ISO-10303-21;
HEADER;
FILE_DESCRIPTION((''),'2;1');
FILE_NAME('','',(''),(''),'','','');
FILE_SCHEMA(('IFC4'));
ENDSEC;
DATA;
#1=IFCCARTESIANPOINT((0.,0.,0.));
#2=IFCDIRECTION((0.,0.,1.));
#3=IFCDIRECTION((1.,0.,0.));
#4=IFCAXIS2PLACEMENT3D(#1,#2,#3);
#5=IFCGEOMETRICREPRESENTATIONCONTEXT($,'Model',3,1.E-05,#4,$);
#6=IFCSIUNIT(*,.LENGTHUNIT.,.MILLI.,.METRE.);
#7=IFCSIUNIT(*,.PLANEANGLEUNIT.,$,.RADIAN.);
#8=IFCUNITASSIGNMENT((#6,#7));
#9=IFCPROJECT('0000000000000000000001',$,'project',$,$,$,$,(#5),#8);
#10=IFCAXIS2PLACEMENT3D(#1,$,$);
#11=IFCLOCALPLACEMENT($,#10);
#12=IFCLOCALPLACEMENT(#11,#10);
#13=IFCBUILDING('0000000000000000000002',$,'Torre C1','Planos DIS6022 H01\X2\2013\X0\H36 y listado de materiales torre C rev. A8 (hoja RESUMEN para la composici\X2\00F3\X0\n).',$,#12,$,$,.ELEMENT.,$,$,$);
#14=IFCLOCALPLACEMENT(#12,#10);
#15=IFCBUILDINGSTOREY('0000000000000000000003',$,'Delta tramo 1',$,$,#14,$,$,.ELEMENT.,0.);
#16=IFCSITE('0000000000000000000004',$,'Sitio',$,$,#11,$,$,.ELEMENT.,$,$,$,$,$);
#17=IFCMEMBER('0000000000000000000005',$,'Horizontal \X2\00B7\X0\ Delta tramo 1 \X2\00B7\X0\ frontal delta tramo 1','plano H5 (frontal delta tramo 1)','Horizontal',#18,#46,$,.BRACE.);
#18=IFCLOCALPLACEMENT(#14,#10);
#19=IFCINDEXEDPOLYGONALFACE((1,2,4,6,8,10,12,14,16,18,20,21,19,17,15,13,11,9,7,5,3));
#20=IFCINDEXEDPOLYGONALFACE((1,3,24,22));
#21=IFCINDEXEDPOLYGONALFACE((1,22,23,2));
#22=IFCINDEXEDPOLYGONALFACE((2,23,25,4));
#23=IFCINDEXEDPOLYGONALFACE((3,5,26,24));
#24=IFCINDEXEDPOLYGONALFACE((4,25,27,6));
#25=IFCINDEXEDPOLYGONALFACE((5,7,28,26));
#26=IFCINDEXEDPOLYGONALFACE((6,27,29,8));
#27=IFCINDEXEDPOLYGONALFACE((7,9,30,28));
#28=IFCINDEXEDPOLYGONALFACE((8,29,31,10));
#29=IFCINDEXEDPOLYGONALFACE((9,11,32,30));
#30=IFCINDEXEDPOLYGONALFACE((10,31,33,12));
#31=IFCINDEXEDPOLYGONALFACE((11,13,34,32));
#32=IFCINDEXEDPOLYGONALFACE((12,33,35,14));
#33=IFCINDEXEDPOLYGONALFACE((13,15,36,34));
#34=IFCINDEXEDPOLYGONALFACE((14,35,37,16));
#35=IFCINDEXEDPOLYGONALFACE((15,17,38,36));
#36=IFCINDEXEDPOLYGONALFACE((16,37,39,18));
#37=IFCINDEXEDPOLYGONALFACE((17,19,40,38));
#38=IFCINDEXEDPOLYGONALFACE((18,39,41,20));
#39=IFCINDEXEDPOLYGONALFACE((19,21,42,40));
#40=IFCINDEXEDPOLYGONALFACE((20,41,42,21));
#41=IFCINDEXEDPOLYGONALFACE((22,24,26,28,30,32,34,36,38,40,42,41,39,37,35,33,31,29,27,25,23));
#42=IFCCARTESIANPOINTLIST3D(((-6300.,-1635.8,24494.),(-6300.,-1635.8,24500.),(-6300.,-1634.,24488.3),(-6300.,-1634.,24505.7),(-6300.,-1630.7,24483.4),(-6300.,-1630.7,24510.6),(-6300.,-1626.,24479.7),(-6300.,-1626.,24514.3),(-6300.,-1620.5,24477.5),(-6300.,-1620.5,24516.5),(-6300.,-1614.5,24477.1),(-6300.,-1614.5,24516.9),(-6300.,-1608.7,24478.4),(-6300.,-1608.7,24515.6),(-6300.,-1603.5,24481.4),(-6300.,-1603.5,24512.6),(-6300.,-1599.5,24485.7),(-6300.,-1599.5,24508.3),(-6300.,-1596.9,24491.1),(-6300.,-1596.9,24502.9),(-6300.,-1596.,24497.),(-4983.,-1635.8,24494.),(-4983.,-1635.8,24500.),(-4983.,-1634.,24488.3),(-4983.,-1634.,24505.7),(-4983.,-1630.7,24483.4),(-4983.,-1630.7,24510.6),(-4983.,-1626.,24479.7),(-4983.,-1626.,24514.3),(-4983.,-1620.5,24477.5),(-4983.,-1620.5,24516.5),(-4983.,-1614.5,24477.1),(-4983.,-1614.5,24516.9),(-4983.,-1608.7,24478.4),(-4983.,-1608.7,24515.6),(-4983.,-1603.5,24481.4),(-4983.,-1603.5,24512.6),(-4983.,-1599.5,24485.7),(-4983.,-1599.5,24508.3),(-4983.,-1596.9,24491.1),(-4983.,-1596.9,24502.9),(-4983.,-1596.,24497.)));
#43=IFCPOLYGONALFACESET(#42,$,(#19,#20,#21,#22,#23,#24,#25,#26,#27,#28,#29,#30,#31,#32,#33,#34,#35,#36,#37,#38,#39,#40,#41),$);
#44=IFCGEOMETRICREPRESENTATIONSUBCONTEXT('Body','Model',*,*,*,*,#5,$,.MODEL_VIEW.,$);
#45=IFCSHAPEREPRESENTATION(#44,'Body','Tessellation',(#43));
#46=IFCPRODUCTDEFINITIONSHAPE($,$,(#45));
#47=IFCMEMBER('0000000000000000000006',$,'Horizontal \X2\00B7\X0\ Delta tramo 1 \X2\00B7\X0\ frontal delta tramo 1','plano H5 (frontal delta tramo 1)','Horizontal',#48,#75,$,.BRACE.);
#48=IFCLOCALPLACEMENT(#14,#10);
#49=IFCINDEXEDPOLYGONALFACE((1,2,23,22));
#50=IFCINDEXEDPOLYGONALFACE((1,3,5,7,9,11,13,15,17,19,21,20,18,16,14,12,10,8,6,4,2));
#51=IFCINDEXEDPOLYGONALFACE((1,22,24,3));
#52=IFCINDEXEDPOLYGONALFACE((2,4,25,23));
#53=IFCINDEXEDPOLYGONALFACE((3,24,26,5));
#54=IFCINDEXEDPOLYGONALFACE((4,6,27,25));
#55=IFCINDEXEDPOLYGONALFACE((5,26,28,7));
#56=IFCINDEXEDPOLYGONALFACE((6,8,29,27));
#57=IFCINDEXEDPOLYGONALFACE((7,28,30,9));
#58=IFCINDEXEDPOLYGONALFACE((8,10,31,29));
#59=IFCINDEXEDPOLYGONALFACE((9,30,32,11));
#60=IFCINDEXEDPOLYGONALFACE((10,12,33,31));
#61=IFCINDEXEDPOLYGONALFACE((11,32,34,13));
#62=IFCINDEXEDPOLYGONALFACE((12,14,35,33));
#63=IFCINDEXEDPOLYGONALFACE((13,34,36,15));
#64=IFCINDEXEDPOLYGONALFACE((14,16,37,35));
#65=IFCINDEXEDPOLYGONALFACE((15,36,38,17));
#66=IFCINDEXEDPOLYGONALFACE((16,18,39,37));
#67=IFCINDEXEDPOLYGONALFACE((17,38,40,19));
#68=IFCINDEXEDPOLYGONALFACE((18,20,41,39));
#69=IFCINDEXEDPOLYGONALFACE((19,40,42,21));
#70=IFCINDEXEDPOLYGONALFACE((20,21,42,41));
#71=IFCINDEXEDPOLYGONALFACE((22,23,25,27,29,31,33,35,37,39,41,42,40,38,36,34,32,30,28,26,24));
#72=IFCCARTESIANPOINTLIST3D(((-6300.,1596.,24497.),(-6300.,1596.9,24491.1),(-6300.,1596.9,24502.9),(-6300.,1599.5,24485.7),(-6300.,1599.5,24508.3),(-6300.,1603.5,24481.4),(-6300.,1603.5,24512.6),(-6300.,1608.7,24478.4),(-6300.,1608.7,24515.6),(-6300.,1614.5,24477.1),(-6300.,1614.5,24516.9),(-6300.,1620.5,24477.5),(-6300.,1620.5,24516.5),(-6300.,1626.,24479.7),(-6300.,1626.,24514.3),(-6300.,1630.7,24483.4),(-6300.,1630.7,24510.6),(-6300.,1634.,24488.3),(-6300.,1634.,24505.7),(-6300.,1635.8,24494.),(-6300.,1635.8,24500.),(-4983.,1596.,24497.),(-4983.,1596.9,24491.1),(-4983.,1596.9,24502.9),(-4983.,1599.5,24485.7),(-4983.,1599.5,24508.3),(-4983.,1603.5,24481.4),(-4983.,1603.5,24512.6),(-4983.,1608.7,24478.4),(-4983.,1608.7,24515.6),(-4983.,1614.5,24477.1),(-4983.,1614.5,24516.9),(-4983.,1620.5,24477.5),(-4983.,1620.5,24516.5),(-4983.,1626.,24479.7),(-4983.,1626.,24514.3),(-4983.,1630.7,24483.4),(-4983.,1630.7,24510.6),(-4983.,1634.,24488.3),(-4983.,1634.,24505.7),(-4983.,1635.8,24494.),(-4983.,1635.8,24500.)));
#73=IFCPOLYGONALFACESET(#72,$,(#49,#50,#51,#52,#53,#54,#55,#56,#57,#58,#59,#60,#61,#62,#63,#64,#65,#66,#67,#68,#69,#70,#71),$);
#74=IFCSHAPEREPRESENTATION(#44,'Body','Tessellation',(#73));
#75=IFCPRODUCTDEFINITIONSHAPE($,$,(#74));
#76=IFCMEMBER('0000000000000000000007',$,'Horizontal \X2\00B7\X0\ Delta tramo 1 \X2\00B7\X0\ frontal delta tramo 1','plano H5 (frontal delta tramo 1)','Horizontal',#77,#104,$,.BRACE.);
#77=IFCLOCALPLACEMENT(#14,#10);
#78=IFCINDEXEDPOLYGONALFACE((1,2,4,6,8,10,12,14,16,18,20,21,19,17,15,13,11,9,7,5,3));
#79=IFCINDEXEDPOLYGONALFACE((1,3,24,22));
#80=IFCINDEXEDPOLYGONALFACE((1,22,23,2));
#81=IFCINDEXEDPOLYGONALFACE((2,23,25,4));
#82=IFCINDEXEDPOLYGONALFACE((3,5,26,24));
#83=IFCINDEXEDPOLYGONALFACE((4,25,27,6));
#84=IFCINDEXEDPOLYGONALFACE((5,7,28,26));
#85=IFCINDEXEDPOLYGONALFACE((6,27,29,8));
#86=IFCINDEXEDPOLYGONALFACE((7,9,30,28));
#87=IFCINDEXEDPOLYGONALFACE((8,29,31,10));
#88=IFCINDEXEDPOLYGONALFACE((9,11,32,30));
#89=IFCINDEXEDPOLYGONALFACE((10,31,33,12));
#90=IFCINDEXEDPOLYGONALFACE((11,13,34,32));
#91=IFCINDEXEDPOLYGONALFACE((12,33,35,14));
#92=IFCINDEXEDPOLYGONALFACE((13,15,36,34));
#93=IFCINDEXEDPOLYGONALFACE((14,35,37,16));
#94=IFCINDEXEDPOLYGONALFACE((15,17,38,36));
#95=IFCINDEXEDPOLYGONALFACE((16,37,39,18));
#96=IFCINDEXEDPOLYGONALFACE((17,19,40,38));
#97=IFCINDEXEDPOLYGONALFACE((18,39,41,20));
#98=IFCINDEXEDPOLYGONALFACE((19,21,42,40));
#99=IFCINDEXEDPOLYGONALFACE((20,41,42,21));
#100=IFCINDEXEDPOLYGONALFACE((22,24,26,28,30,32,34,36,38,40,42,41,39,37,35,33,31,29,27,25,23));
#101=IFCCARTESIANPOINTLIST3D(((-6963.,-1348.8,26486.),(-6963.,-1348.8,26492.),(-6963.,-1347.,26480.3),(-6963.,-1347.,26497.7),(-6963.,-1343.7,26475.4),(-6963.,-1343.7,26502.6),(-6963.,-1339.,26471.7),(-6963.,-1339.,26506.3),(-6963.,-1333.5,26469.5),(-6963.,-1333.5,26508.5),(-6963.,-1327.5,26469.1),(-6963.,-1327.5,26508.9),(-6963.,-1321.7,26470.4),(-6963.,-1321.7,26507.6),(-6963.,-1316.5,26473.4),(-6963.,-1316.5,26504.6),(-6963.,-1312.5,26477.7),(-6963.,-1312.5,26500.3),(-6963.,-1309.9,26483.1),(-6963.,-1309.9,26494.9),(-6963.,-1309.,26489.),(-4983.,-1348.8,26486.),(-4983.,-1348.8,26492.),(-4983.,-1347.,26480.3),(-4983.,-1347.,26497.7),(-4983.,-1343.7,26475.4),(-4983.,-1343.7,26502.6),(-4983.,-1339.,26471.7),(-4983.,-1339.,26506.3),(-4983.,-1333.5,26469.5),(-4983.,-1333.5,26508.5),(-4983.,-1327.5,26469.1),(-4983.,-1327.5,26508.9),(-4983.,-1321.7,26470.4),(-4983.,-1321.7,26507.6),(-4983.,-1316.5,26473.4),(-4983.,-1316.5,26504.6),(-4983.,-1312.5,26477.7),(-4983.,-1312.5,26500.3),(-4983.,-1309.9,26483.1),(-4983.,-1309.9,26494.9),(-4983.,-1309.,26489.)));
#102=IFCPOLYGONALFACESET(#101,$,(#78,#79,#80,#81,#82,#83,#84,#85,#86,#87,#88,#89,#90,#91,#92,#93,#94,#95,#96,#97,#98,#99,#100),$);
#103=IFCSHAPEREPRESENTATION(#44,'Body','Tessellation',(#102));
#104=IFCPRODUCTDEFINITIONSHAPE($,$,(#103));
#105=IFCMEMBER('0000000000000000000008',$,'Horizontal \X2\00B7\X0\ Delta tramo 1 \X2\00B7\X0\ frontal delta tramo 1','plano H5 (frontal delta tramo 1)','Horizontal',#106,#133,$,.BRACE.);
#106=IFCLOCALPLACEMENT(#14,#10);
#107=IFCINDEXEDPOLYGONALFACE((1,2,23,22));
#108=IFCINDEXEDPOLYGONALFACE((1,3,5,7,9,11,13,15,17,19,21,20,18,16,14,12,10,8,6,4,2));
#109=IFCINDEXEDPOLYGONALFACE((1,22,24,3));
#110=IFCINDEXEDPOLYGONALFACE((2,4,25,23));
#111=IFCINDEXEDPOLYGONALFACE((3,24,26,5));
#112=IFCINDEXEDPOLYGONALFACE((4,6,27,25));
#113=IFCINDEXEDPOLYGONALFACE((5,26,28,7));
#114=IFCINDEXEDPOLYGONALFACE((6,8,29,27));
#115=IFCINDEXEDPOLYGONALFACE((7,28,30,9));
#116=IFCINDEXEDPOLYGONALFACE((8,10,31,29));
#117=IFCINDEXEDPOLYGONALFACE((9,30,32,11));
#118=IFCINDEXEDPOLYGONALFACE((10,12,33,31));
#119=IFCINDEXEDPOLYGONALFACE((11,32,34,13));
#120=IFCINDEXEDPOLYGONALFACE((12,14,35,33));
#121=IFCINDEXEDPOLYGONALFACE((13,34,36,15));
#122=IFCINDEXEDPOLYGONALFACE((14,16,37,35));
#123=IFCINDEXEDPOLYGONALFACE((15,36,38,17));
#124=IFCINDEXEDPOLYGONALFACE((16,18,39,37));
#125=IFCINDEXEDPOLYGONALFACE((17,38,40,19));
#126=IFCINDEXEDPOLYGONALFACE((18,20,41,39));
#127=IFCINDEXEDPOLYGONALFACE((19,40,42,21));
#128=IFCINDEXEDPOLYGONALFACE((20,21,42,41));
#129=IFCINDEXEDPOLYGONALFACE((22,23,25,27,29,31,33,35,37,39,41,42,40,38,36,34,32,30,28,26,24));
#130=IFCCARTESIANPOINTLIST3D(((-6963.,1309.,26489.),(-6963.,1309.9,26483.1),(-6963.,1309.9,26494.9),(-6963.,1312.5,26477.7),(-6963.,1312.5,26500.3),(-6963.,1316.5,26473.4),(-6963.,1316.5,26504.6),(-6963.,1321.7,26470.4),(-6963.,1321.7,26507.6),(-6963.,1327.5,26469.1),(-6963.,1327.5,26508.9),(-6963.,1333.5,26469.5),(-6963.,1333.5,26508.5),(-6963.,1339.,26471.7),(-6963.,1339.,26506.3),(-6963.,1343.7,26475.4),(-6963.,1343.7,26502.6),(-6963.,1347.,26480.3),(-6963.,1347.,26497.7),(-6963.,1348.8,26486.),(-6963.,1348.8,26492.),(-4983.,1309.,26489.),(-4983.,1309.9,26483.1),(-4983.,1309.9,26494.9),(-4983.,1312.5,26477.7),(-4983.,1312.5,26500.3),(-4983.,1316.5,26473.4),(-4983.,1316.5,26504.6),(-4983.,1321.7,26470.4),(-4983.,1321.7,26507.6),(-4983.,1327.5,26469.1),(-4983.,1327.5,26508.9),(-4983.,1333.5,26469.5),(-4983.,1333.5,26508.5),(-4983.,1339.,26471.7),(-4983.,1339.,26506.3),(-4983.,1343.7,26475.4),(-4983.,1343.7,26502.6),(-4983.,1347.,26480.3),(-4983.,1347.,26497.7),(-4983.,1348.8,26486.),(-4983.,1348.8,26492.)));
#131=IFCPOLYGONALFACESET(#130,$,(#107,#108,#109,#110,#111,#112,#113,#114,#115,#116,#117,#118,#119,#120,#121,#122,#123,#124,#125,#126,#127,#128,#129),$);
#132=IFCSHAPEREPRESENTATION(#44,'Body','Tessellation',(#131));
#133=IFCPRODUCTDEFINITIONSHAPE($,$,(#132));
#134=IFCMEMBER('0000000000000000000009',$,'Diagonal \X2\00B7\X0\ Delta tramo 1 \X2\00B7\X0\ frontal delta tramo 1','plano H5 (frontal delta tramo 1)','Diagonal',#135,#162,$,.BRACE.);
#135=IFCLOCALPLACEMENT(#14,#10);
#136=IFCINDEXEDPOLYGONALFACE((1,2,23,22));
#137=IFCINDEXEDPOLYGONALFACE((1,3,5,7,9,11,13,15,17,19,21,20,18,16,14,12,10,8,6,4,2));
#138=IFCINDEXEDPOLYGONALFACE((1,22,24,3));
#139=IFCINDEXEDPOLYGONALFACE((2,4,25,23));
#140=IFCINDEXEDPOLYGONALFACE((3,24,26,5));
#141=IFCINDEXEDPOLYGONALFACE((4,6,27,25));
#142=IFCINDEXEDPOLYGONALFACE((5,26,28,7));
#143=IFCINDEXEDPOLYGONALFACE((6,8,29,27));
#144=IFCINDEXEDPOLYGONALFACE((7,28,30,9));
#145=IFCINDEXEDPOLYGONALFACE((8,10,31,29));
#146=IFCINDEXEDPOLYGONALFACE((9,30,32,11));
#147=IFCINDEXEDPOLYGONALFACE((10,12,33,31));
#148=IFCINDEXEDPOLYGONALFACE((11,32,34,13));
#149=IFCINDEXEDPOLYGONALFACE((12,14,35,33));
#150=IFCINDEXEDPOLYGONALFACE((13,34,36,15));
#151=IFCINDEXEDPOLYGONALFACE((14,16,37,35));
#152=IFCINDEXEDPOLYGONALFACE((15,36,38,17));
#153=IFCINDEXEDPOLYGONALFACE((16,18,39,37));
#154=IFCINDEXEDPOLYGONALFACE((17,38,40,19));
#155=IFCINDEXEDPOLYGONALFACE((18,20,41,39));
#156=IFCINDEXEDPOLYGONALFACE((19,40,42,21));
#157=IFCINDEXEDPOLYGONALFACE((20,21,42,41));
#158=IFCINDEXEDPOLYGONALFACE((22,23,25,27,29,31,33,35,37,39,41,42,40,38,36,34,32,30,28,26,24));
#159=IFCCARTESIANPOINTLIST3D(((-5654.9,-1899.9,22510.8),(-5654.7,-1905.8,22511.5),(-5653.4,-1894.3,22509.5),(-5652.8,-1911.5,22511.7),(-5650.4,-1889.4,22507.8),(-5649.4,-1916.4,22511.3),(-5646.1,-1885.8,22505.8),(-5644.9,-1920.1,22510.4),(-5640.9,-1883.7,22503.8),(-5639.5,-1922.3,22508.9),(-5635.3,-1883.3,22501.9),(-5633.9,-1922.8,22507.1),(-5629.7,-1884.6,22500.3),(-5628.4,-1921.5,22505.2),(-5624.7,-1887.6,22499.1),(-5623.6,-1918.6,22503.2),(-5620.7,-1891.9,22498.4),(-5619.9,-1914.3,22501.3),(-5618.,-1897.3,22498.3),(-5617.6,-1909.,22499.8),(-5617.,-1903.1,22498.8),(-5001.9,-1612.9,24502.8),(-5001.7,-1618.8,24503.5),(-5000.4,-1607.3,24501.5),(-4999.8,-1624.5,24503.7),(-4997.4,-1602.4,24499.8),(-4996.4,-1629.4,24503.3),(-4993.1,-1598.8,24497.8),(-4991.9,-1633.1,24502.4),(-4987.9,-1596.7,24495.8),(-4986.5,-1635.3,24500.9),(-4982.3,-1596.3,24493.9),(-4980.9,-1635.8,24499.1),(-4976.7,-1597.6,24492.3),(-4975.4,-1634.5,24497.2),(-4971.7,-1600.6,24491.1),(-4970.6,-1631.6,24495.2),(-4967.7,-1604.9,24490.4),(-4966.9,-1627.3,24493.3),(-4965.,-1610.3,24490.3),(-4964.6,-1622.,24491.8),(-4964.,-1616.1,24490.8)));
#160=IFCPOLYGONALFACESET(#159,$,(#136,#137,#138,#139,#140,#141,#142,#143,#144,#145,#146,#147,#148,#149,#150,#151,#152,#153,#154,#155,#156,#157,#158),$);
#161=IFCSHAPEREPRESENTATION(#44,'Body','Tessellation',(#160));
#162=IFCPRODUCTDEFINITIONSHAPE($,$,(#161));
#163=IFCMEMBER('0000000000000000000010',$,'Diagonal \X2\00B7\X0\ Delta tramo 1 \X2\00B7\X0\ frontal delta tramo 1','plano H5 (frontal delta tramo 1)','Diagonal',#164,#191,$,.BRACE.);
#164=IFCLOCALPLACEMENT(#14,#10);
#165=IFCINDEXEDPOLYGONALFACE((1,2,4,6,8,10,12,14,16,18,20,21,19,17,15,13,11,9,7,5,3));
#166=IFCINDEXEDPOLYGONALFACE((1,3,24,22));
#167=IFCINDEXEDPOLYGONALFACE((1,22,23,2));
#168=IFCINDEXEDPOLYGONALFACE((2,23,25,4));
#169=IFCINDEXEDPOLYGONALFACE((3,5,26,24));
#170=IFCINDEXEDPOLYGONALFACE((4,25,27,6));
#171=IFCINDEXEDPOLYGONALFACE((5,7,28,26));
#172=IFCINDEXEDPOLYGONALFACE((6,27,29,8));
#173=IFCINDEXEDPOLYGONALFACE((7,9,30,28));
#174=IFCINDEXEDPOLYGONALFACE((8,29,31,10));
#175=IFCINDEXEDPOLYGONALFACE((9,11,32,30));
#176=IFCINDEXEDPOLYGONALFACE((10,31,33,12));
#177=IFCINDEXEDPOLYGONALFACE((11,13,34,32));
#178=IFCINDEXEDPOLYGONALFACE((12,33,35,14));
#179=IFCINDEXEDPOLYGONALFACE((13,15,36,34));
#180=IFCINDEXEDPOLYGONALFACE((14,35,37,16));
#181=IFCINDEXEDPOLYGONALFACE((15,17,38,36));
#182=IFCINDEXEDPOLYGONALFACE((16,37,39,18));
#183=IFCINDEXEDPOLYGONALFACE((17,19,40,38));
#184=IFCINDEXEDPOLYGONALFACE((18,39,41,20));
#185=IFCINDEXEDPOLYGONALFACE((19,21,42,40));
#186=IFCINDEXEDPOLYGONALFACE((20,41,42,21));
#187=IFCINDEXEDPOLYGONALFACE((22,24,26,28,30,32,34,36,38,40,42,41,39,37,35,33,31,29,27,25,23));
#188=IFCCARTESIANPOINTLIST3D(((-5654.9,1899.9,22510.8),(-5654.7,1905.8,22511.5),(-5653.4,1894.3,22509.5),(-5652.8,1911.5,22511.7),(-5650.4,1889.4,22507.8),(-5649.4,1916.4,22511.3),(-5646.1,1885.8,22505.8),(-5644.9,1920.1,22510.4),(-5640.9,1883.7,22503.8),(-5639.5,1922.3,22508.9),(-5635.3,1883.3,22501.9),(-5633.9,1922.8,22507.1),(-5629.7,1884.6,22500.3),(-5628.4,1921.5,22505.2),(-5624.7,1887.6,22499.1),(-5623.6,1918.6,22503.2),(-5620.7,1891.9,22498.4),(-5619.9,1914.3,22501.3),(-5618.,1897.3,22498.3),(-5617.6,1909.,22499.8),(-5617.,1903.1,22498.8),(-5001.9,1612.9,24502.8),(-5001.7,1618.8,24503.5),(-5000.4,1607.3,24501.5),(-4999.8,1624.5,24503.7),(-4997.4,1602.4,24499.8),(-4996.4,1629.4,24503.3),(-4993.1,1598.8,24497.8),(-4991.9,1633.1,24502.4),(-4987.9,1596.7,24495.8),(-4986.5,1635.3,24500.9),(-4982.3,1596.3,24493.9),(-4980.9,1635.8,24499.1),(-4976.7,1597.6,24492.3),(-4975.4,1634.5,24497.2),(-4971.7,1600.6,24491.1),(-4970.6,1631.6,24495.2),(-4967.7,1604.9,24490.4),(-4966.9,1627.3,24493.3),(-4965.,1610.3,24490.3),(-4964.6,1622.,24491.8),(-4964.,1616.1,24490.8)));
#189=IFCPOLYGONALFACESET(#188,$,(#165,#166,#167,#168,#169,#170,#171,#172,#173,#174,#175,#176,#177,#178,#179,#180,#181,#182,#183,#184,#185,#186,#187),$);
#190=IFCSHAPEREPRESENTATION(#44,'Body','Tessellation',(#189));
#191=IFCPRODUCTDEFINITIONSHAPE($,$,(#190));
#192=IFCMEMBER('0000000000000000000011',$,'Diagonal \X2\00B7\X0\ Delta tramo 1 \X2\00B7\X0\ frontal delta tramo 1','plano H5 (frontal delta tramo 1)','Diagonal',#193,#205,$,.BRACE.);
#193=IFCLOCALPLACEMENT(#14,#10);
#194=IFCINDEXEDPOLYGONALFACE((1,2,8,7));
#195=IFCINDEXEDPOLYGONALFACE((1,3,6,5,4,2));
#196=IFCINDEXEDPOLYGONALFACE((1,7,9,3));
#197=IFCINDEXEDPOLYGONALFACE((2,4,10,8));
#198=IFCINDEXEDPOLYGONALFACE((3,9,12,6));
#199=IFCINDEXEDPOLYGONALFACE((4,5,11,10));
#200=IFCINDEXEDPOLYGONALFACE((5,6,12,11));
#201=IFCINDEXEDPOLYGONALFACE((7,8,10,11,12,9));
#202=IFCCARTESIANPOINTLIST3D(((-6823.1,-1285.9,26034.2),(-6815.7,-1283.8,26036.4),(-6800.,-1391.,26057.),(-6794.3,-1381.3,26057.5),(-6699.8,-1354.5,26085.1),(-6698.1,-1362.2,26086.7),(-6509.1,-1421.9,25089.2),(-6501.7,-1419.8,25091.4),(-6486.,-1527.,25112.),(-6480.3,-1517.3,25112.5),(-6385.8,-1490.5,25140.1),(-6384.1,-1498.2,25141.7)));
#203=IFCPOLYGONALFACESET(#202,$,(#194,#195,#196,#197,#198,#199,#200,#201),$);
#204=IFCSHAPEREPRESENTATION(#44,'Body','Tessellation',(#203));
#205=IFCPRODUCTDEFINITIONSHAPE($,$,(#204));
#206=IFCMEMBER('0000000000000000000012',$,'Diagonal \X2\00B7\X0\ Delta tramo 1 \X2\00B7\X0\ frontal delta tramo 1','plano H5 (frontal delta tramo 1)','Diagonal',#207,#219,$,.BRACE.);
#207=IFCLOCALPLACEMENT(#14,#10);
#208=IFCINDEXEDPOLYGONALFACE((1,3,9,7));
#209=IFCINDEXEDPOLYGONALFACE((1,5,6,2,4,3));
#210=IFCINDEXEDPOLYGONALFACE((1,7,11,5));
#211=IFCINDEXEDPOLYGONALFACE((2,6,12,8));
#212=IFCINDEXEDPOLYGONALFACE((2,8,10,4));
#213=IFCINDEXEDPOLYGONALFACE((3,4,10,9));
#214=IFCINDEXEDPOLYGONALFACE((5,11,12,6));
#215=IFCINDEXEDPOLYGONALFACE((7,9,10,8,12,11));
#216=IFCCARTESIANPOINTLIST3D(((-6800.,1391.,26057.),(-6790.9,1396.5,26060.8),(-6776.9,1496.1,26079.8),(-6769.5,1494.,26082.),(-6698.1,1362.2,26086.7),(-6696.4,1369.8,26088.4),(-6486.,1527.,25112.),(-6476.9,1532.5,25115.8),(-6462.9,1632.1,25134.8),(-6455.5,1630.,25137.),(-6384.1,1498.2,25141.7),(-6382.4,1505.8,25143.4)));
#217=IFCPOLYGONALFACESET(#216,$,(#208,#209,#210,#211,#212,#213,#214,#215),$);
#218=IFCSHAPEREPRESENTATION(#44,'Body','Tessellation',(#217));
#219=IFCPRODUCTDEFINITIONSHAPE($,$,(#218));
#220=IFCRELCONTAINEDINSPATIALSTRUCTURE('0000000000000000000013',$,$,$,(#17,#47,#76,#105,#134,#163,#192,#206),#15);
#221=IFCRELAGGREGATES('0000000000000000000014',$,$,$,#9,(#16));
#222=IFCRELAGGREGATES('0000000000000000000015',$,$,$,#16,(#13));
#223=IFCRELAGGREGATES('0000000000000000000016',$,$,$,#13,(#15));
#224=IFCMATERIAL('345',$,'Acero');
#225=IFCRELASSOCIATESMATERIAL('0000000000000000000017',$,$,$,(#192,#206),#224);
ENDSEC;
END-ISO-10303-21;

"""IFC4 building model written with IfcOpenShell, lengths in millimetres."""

from ifc_helpers import new_model, si_unit, frame, frame_2d, origin, origin_with_axes, place, context, subcontext, project, spatial, circle, l_section, extrude, material, element, save


model = new_model("IFC4")

# Units and contexts
model_context = context("Model", 3, precision=1e-05, world=origin_with_axes())
body_context = subcontext(model_context, "Body", "Model", "MODEL_VIEW")
ifc_project = project(units=[si_unit("LENGTHUNIT", "METRE", prefix="MILLI"), si_unit("PLANEANGLEUNIT", "RADIAN")], contexts=[model_context])

# Site, building, storey
site_placement = place(None, origin())
site = spatial("IfcSite", under=ifc_project, at=site_placement, Name="Sitio", CompositionType="ELEMENT")
building_placement = place(site_placement, origin())
building = spatial("IfcBuilding", under=site, at=building_placement, Name="Torre C1", Description="Planos DIS6022 H01–H36 y listado de materiales torre C rev. A8 (hoja RESUMEN para la composición).", CompositionType="ELEMENT")
storey_placement = place(building_placement, origin())
storey = spatial("IfcBuildingStorey", under=building, at=storey_placement, Name="Delta tramo 1", CompositionType="ELEMENT", Elevation=0.0)

# Members
for number, where, z_axis, x_axis, name in (
    (1, (-6300.0, -1616.0, 24497.0), (1.0, 0.0, 0.0), (0.0, 1.0, 0.0), "Horizontal · Delta tramo 1 · frontal delta tramo 1"),
    (2, (-6300.0, 1616.0, 24497.0), (1.0, 0.0, 0.0), (0.0, -1.0, 0.0), "Horizontal · Delta tramo 1 · frontal delta tramo 1"),
):
    element("IfcMember", number, at=place(storey_placement, frame(where, z_axis=z_axis, x_axis=x_axis)), inside=storey, Name=name, Description="plano H5 (frontal delta tramo 1)", ObjectType="Horizontal", PredefinedType="BRACE", context=body_context, shape_type="SweptSolid", body=[
        extrude(circle(Radius=20.0), None, (0.0, 0.0, 1.0), 1317.0),
    ])
for number, where, z_axis, x_axis, name in (
    (3, (-6963.0, -1329.0, 26489.0), (1.0, 0.0, 0.0), (0.0, 1.0, 0.0), "Horizontal · Delta tramo 1 · frontal delta tramo 1"),
    (4, (-6963.0, 1329.0, 26489.0), (1.0, 0.0, 0.0), (0.0, -1.0, 0.0), "Horizontal · Delta tramo 1 · frontal delta tramo 1"),
):
    element("IfcMember", number, at=place(storey_placement, frame(where, z_axis=z_axis, x_axis=x_axis)), inside=storey, Name=name, Description="plano H5 (frontal delta tramo 1)", ObjectType="Horizontal", PredefinedType="BRACE", context=body_context, shape_type="SweptSolid", body=[
        extrude(circle(Radius=20.0), None, (0.0, 0.0, 1.0), 1980.0),
    ])
for number, where, z_axis, x_axis, name in (
    (5, (-4983.0, -1616.0, 24497.0), (-0.308622, -0.135643, -0.941463), (0.897727, 0.285606, -0.335434), "Diagonal · Delta tramo 1 · frontal delta tramo 1"),
    (6, (-4983.0, 1616.0, 24497.0), (-0.308622, 0.135643, -0.941463), (0.897727, -0.285606, -0.335434), "Diagonal · Delta tramo 1 · frontal delta tramo 1"),
):
    element("IfcMember", number, at=place(storey_placement, frame(where, z_axis=z_axis, x_axis=x_axis)), inside=storey, Name=name, Description="plano H5 (frontal delta tramo 1)", ObjectType="Diagonal", PredefinedType="BRACE", context=body_context, shape_type="SweptSolid", body=[
        extrude(circle(Radius=20.0), None, (0.0, 0.0, 1.0), 2115.9),
    ])
ifc_material_1 = material(Name="345", Category="Acero")
for number, where, z_axis, x_axis, name in (
    (7, (-6486.0, -1527.0, 25112.0), (-0.312424, 0.135317, 0.940256), (0.926472, 0.26207, 0.270128), "Diagonal · Delta tramo 1 · frontal delta tramo 1"),
    (8, (-6486.0, 1527.0, 25112.0), (-0.312424, -0.135317, 0.940256), (0.926472, -0.26207, 0.270128), "Diagonal · Delta tramo 1 · frontal delta tramo 1"),
):
    element("IfcMember", number, at=place(storey_placement, frame(where, z_axis=z_axis, x_axis=x_axis)), inside=storey, material=ifc_material_1, Name=name, Description="plano H5 (frontal delta tramo 1)", ObjectType="Diagonal", PredefinedType="BRACE", context=body_context, shape_type="SweptSolid", body=[
        extrude(l_section(Depth=110.0, Width=110.0, Thickness=8.0, at=frame_2d((55.0, 55.0))), None, (0.0, 0.0, 1.0), 1005.0),
    ])

save(model, "model.ifc")
